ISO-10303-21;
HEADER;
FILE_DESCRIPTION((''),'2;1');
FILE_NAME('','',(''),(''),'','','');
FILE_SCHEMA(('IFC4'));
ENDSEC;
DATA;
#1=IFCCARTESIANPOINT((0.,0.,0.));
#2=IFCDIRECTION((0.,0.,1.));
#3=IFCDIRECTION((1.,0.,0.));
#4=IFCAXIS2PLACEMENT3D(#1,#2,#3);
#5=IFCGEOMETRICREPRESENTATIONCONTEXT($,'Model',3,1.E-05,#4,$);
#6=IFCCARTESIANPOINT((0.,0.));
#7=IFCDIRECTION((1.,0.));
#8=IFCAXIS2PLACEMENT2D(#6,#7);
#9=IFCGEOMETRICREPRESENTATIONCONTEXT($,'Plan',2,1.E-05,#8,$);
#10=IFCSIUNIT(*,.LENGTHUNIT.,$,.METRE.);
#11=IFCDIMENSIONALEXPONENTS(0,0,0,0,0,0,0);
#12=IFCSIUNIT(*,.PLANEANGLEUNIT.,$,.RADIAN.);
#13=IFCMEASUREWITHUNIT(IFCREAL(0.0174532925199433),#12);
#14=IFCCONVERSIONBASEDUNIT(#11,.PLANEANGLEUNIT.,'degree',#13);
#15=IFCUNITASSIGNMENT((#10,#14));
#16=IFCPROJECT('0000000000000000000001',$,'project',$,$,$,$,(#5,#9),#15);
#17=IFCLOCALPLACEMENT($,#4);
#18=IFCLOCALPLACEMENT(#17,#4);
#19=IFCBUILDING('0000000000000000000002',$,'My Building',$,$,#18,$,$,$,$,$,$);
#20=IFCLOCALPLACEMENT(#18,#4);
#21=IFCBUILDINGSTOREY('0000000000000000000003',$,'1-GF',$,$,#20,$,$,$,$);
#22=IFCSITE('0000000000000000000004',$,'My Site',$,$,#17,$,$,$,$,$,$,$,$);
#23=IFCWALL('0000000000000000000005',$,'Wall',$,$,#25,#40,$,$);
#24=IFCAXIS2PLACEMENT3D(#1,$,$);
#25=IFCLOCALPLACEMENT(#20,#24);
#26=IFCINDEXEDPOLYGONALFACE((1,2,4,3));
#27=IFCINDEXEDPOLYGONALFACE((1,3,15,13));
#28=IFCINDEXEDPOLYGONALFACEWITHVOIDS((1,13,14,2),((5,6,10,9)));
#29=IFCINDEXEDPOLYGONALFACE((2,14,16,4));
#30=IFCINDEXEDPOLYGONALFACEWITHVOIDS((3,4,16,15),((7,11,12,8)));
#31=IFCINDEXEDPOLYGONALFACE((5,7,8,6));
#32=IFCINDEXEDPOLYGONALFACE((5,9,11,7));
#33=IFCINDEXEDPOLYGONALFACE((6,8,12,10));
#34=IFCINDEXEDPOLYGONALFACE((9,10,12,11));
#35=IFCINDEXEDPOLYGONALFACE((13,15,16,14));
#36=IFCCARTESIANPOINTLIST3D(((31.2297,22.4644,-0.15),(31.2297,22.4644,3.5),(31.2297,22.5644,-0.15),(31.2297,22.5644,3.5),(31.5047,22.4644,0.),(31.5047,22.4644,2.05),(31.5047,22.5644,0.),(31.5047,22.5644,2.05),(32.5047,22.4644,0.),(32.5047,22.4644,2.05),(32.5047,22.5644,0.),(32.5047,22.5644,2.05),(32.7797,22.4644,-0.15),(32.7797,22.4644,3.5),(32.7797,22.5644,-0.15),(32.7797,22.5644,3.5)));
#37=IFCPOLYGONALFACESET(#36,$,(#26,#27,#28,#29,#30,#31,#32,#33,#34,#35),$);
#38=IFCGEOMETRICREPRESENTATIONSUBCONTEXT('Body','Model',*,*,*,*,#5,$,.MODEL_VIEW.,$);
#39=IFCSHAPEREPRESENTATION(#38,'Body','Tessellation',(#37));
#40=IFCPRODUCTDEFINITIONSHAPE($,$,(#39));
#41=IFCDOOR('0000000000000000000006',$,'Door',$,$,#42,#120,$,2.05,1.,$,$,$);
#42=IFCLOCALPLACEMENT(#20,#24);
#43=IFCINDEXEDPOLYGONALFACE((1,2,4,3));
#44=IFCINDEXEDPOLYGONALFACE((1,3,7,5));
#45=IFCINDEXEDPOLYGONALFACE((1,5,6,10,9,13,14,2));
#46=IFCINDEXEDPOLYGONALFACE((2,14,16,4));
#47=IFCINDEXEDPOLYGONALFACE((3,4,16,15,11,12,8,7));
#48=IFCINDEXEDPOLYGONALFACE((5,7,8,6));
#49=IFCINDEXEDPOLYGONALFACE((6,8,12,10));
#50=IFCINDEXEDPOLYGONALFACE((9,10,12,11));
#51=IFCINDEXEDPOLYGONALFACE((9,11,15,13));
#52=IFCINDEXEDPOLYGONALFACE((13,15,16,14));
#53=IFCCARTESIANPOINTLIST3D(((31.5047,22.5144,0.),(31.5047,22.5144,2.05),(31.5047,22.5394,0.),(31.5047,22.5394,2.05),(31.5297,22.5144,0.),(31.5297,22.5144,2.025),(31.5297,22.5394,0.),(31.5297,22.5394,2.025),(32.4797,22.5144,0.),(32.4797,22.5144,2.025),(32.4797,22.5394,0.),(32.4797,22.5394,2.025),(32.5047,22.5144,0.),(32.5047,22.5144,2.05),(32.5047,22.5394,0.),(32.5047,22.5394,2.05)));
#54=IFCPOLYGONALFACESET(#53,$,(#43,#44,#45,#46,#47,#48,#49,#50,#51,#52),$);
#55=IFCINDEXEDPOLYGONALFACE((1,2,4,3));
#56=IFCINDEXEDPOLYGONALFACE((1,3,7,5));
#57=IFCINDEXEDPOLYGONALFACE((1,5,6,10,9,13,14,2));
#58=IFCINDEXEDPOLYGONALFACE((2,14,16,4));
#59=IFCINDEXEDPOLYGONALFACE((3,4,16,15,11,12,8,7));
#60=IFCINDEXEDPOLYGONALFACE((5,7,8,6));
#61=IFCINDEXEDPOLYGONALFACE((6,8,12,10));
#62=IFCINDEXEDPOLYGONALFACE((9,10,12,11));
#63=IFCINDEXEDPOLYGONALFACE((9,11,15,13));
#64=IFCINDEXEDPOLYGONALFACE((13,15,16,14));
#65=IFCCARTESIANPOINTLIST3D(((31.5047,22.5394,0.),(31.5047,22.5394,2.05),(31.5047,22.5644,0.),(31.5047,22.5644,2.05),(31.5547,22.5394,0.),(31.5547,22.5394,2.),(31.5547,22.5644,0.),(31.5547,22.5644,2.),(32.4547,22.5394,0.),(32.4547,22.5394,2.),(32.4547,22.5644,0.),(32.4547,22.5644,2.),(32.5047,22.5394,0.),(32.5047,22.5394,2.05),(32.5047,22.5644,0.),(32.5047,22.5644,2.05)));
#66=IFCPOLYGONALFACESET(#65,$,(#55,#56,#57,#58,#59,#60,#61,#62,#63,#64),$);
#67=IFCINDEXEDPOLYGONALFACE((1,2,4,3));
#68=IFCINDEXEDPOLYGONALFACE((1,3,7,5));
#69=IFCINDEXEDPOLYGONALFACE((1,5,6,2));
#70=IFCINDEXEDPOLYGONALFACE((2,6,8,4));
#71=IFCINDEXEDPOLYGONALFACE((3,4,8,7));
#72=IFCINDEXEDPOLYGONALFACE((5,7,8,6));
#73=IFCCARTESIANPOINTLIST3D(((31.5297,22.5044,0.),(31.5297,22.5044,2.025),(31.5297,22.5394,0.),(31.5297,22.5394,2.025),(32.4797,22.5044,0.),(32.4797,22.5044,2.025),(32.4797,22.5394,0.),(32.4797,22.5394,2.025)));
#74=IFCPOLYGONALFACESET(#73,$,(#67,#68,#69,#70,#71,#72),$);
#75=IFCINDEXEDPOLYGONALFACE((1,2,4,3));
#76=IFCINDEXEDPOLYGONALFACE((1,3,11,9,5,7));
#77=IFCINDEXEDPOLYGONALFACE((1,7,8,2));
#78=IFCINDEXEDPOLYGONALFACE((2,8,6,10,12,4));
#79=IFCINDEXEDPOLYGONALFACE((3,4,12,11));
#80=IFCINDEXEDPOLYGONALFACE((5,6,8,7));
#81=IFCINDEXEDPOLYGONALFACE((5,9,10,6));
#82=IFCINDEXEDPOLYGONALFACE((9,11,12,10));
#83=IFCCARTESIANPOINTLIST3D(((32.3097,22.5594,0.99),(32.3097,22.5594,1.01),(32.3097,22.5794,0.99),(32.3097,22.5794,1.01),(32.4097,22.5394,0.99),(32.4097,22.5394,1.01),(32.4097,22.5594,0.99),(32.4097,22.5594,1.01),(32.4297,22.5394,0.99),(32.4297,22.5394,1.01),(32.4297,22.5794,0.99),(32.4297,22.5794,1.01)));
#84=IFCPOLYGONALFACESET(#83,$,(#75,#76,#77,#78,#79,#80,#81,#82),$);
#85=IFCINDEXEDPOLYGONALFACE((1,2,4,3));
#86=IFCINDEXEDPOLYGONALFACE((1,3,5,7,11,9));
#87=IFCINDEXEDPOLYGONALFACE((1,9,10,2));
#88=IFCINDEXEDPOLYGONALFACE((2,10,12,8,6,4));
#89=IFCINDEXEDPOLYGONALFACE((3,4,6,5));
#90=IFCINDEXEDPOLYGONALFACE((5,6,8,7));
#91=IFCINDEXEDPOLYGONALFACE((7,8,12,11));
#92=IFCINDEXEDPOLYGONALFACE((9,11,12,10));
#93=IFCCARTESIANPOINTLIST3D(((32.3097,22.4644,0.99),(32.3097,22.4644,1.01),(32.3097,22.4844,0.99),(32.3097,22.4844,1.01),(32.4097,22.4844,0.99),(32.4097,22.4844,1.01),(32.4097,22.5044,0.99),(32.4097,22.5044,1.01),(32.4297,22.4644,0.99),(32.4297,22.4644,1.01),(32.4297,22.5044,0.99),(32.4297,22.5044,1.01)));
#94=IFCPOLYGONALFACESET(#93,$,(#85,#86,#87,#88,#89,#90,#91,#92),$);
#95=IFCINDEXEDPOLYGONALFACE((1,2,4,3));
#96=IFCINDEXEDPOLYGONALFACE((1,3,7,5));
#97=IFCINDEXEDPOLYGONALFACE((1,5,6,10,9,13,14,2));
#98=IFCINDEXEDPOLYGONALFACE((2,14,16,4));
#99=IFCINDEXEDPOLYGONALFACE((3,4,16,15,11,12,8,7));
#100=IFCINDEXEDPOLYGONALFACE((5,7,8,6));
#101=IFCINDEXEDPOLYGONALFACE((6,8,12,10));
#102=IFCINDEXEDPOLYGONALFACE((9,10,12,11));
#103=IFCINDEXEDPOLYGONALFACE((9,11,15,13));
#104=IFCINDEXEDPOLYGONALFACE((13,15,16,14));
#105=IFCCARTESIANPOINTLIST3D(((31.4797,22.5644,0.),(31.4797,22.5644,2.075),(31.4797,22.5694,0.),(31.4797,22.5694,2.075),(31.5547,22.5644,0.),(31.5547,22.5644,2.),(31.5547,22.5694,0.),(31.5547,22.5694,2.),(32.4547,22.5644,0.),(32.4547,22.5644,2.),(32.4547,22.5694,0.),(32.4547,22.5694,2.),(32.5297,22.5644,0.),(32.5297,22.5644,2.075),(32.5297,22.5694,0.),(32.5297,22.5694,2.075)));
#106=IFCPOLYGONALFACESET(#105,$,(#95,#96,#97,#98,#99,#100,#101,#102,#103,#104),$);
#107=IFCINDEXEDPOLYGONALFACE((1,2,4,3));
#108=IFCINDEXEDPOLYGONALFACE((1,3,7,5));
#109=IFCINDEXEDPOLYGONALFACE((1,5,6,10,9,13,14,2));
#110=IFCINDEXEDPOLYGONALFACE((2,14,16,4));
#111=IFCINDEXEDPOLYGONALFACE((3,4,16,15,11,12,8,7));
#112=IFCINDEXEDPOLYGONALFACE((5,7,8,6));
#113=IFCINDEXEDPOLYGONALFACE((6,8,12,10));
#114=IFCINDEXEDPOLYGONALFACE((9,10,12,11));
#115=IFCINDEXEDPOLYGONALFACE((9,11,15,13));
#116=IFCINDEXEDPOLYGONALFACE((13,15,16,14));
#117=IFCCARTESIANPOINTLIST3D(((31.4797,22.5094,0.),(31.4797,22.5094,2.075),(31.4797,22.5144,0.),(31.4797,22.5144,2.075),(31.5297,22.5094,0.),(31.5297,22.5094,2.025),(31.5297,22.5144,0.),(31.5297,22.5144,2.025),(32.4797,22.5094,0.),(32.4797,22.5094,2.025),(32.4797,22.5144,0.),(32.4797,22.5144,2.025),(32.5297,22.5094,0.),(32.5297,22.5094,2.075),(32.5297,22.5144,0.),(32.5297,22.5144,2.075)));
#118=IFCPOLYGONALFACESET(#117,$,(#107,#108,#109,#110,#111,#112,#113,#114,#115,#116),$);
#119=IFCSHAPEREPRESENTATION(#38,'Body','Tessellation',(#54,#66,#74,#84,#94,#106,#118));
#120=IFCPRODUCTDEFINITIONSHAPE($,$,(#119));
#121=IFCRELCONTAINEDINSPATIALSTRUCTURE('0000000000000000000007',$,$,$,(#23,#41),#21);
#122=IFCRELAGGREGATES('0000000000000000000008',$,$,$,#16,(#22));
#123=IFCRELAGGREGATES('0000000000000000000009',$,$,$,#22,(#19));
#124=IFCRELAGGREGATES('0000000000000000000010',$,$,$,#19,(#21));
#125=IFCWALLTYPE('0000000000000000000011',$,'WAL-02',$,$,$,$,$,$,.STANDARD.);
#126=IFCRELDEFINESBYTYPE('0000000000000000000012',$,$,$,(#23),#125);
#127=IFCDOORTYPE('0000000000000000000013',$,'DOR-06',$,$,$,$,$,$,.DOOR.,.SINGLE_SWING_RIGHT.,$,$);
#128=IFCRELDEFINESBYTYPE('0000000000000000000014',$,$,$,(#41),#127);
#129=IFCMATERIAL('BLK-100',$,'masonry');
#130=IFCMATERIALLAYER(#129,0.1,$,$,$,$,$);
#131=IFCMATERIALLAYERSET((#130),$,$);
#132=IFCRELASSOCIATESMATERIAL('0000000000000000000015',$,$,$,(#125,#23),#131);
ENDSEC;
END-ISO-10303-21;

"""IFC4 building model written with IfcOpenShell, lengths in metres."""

from ifc_helpers import new_model, entity, si_unit, converted_unit, frame, origin_with_axes, origin_2d_with_axis, place, context, subcontext, project, spatial, line, indexed_curve, outline, extrude, shape, source, transform, mapped, material, layer, layer_set, layer_usage, type_object, type_shapes, element, fill, save


model = new_model("IFC4")

# Units and contexts
model_context = context("Model", 3, precision=1e-05, world=origin_with_axes())
plan_context = context("Plan", 2, precision=1e-05, world=origin_2d_with_axis())
body_context_1 = subcontext(model_context, "Body", "Model", "MODEL_VIEW")
body_context_2 = subcontext(plan_context, "Body", "Plan", "PLAN_VIEW")
ifc_project = project(units=[si_unit("LENGTHUNIT", "METRE"), converted_unit("PLANEANGLEUNIT", "degree", entity("IfcReal", 0.0174532925199433), si_unit("PLANEANGLEUNIT", "RADIAN"), dimensions=[0, 0, 0, 0, 0, 0, 0])], contexts=[model_context, plan_context])

# Site, building, storey
site_placement = place(None, origin_with_axes())
site = spatial("IfcSite", under=ifc_project, at=site_placement, Name="My Site")
building_placement = place(site_placement, origin_with_axes())
building = spatial("IfcBuilding", under=site, at=building_placement, Name="My Building")
storey_placement = place(building_placement, origin_with_axes())
storey = spatial("IfcBuildingStorey", under=building, at=storey_placement, Name="1-GF")

# Shared definitions
ifc_material_1 = material(Name="BLK-100", Category="masonry")
ifc_layer_1 = layer(ifc_material_1, 0.1)
ifc_layer_set_1 = layer_set([ifc_layer_1])
wall_type = type_object("IfcWallType", Name="WAL-02", PredefinedType="STANDARD", material=ifc_layer_set_1)

# Wall, opening, door
ifc_layer_usage_1 = layer_usage(ifc_layer_set_1, "AXIS2", "POSITIVE", 0.0)
wall_1_placement = place(storey_placement, frame((32.7797, 22.5644, -0.15), z_axis=(0.0, 0.0, 1.0), x_axis=(-1.0, 0.0, 0.0)))
wall_1 = element("IfcWall", 1, at=wall_1_placement, inside=storey, type_object=wall_type, material=ifc_layer_usage_1, Name="Wall", context=body_context_1, shape_type="SweptSolid", body=[
    extrude(outline(indexed_curve([(0.0, 0.0), (0.0, 0.1), (1.55, 0.1), (1.55, 0.0), (0.0, 0.0)], self_intersect=False)), origin_with_axes(), (0.0, 0.0, 1.0), 3.65),
])
shared_shape_1 = source(origin_with_axes(), body_context_1, "Body", "SweptSolid", [
    extrude(outline(indexed_curve([(0.0, 0.0), (1.0, 0.0), (1.0, 2.05), (0.0, 2.05)], segments=[line(1, 2, 3, 4, 1)])), frame((0.0, -0.6, 0.0), z_axis=(0.0, -1.0, 0.0), x_axis=(1.0, 0.0, 0.0)), (0.0, 0.0, -1.0), 1.2),
])
opening_1_placement = place(wall_1_placement, frame((0.275, 0.0, 0.15), z_axis=(0.0, 0.0, 1.0), x_axis=(1.0, 0.0, 0.0)))
opening_1 = element("IfcOpeningElement", 2, at=opening_1_placement, cuts=wall_1, PredefinedType="OPENING", context=body_context_1, shape_type="MappedRepresentation", body=[
    mapped(shared_shape_1, transform((0.0, 0.0, 0.0), x_axis=(1.0, 0.0, 0.0), y_axis=(0.0, 1.0, 0.0), z_axis=(0.0, 0.0, 1.0), scale=1.0)),
])
door_type_1 = type_object("IfcDoorType", Name="DOR-06", OperationType="SINGLE_SWING_RIGHT", PredefinedType="DOOR")
shared_shape_2 = source(origin_with_axes(), body_context_1, "Body", "SweptSolid", [
    extrude(outline(indexed_curve([(0.0, 0.0), (0.0, 2.05), (1.0, 2.05), (1.0, 0.0), (0.975, 0.0), (0.975, 2.025), (0.025, 2.025), (0.025, 0.0)], segments=[line(1, 2, 3, 4, 5, 6, 7, 8, 1)])), frame((0.0, 0.025, 0.0), z_axis=(0.0, -1.0, 0.0), x_axis=(1.0, 0.0, 0.0)), (0.0, 0.0, -1.0), 0.025),
    extrude(outline(indexed_curve([(0.0, 0.0), (0.0, 2.05), (1.0, 2.05), (1.0, 0.0), (0.95, 0.0), (0.95, 2.0), (0.05, 2.0), (0.05, 0.0)], segments=[line(1, 2, 3, 4, 5, 6, 7, 8, 1)])), frame((0.0, 0.0, 0.0), z_axis=(0.0, -1.0, 0.0), x_axis=(1.0, 0.0, 0.0)), (0.0, 0.0, -1.0), 0.025),
    extrude(outline(indexed_curve([(0.0, 0.0), (0.95, 0.0), (0.95, 0.035), (0.0, 0.035)], segments=[line(1, 2, 3, 4, 1)])), frame((0.025, 0.025, 0.0), z_axis=(0.0, 0.0, 1.0), x_axis=(1.0, 0.0, 0.0)), (0.0, 0.0, 1.0), 2.025),
    extrude(outline(indexed_curve([(0.0, 0.0), (0.0, -0.04), (0.12, -0.04), (0.12, -0.02), (0.02, -0.02), (0.02, 0.0)], segments=[line(1, 2, 3, 4, 5, 6, 1)])), frame((0.075, 0.025, 0.99), z_axis=(0.0, 0.0, 1.0), x_axis=(1.0, 0.0, 0.0)), (0.0, 0.0, 1.0), 0.02),
    extrude(outline(indexed_curve([(0.0, 0.0), (0.0, 0.04), (0.12, 0.04), (0.12, 0.02), (0.02, 0.02), (0.02, 0.0)], segments=[line(1, 2, 3, 4, 5, 6, 1)])), frame((0.075, 0.06, 0.99), z_axis=(0.0, 0.0, 1.0), x_axis=(1.0, 0.0, 0.0)), (0.0, 0.0, 1.0), 0.02),
    extrude(outline(indexed_curve([(0.0, 0.0), (0.0, 2.075), (1.05, 2.075), (1.05, 0.0), (0.975, 0.0), (0.975, 2.0), (0.075, 2.0), (0.075, 0.0)], segments=[line(1, 2, 3, 4, 5, 6, 7, 8, 1)])), frame((-0.025, -0.005, 0.0), z_axis=(0.0, -1.0, 0.0), x_axis=(1.0, 0.0, 0.0)), (0.0, 0.0, -1.0), 0.005),
    extrude(outline(indexed_curve([(0.0, 0.0), (0.0, 2.075), (1.05, 2.075), (1.05, 0.0), (1.0, 0.0), (1.0, 2.025), (0.05, 2.025), (0.05, 0.0)], segments=[line(1, 2, 3, 4, 5, 6, 7, 8, 1)])), frame((-0.025, 0.05, 0.0), z_axis=(0.0, -1.0, 0.0), x_axis=(1.0, 0.0, 0.0)), (0.0, 0.0, -1.0), 0.005),
])
shared_shape_3 = source(origin_with_axes(), body_context_2, "Body", "Curve2D", [
    entity("IfcIndexedPolyCurve", entity("IfcCartesianPointList2D", [[0.0, 0.0], [0.0, 0.05], [0.025, 0.05], [0.025, 0.025], [0.05, 0.025], [0.05, 0.0]]), [entity("IfcLineIndex", [1, 2, 3, 4, 5, 6, 1])]),
    entity("IfcIndexedPolyCurve", entity("IfcCartesianPointList2D", [[1.0, 0.0], [1.0, 0.05], [0.975, 0.05], [0.975, 0.025], [0.95, 0.025], [0.95, 0.0]]), [entity("IfcLineIndex", [1, 2, 3, 4, 5, 6, 1])]),
    entity("IfcTrimmedCurve", entity("IfcEllipse", entity("IfcAxis2Placement2D", entity("IfcCartesianPoint", [0.94, 0.05]), entity("IfcDirection", [1.0, 0.0])), 0.915, 0.95), [entity("IfcCartesianPoint", [0.94, 1.0])], [entity("IfcCartesianPoint", [0.025, 0.05])], True, "CARTESIAN"),
    entity("IfcIndexedPolyCurve", entity("IfcCartesianPointList2D", [[0.975, 0.05], [0.94, 0.05], [0.94, 1.0], [0.975, 1.0]]), [entity("IfcLineIndex", [1, 2, 3, 4, 1])]),
])
type_shapes(door_type_1, [shared_shape_2, shared_shape_3])
door_1_placement = place(opening_1_placement, frame((0.0, 0.0, 0.0), z_axis=(0.0, 0.0, 1.0), x_axis=(1.0, 0.0, 0.0)))
door_1 = element("IfcDoor", 3, at=door_1_placement, inside=storey, type_object=door_type_1, Name="Door", OverallHeight=2.05, OverallWidth=1.0, shapes=[
    shape(body_context_1, "Body", "MappedRepresentation", [mapped(shared_shape_2, transform((0.0, 0.0, 0.0), x_axis=(1.0, 0.0, 0.0), y_axis=(0.0, 1.0, 0.0), z_axis=(0.0, 0.0, 1.0), scale=1.0))]),
    shape(body_context_2, "Body", "MappedRepresentation", [mapped(shared_shape_3, transform((0.0, 0.0, 0.0), x_axis=(1.0, 0.0, 0.0), y_axis=(0.0, 1.0, 0.0), z_axis=(0.0, 0.0, 1.0), scale=1.0))]),
])
fill(opening_1, door_1)

save(model, "model.ifc")
